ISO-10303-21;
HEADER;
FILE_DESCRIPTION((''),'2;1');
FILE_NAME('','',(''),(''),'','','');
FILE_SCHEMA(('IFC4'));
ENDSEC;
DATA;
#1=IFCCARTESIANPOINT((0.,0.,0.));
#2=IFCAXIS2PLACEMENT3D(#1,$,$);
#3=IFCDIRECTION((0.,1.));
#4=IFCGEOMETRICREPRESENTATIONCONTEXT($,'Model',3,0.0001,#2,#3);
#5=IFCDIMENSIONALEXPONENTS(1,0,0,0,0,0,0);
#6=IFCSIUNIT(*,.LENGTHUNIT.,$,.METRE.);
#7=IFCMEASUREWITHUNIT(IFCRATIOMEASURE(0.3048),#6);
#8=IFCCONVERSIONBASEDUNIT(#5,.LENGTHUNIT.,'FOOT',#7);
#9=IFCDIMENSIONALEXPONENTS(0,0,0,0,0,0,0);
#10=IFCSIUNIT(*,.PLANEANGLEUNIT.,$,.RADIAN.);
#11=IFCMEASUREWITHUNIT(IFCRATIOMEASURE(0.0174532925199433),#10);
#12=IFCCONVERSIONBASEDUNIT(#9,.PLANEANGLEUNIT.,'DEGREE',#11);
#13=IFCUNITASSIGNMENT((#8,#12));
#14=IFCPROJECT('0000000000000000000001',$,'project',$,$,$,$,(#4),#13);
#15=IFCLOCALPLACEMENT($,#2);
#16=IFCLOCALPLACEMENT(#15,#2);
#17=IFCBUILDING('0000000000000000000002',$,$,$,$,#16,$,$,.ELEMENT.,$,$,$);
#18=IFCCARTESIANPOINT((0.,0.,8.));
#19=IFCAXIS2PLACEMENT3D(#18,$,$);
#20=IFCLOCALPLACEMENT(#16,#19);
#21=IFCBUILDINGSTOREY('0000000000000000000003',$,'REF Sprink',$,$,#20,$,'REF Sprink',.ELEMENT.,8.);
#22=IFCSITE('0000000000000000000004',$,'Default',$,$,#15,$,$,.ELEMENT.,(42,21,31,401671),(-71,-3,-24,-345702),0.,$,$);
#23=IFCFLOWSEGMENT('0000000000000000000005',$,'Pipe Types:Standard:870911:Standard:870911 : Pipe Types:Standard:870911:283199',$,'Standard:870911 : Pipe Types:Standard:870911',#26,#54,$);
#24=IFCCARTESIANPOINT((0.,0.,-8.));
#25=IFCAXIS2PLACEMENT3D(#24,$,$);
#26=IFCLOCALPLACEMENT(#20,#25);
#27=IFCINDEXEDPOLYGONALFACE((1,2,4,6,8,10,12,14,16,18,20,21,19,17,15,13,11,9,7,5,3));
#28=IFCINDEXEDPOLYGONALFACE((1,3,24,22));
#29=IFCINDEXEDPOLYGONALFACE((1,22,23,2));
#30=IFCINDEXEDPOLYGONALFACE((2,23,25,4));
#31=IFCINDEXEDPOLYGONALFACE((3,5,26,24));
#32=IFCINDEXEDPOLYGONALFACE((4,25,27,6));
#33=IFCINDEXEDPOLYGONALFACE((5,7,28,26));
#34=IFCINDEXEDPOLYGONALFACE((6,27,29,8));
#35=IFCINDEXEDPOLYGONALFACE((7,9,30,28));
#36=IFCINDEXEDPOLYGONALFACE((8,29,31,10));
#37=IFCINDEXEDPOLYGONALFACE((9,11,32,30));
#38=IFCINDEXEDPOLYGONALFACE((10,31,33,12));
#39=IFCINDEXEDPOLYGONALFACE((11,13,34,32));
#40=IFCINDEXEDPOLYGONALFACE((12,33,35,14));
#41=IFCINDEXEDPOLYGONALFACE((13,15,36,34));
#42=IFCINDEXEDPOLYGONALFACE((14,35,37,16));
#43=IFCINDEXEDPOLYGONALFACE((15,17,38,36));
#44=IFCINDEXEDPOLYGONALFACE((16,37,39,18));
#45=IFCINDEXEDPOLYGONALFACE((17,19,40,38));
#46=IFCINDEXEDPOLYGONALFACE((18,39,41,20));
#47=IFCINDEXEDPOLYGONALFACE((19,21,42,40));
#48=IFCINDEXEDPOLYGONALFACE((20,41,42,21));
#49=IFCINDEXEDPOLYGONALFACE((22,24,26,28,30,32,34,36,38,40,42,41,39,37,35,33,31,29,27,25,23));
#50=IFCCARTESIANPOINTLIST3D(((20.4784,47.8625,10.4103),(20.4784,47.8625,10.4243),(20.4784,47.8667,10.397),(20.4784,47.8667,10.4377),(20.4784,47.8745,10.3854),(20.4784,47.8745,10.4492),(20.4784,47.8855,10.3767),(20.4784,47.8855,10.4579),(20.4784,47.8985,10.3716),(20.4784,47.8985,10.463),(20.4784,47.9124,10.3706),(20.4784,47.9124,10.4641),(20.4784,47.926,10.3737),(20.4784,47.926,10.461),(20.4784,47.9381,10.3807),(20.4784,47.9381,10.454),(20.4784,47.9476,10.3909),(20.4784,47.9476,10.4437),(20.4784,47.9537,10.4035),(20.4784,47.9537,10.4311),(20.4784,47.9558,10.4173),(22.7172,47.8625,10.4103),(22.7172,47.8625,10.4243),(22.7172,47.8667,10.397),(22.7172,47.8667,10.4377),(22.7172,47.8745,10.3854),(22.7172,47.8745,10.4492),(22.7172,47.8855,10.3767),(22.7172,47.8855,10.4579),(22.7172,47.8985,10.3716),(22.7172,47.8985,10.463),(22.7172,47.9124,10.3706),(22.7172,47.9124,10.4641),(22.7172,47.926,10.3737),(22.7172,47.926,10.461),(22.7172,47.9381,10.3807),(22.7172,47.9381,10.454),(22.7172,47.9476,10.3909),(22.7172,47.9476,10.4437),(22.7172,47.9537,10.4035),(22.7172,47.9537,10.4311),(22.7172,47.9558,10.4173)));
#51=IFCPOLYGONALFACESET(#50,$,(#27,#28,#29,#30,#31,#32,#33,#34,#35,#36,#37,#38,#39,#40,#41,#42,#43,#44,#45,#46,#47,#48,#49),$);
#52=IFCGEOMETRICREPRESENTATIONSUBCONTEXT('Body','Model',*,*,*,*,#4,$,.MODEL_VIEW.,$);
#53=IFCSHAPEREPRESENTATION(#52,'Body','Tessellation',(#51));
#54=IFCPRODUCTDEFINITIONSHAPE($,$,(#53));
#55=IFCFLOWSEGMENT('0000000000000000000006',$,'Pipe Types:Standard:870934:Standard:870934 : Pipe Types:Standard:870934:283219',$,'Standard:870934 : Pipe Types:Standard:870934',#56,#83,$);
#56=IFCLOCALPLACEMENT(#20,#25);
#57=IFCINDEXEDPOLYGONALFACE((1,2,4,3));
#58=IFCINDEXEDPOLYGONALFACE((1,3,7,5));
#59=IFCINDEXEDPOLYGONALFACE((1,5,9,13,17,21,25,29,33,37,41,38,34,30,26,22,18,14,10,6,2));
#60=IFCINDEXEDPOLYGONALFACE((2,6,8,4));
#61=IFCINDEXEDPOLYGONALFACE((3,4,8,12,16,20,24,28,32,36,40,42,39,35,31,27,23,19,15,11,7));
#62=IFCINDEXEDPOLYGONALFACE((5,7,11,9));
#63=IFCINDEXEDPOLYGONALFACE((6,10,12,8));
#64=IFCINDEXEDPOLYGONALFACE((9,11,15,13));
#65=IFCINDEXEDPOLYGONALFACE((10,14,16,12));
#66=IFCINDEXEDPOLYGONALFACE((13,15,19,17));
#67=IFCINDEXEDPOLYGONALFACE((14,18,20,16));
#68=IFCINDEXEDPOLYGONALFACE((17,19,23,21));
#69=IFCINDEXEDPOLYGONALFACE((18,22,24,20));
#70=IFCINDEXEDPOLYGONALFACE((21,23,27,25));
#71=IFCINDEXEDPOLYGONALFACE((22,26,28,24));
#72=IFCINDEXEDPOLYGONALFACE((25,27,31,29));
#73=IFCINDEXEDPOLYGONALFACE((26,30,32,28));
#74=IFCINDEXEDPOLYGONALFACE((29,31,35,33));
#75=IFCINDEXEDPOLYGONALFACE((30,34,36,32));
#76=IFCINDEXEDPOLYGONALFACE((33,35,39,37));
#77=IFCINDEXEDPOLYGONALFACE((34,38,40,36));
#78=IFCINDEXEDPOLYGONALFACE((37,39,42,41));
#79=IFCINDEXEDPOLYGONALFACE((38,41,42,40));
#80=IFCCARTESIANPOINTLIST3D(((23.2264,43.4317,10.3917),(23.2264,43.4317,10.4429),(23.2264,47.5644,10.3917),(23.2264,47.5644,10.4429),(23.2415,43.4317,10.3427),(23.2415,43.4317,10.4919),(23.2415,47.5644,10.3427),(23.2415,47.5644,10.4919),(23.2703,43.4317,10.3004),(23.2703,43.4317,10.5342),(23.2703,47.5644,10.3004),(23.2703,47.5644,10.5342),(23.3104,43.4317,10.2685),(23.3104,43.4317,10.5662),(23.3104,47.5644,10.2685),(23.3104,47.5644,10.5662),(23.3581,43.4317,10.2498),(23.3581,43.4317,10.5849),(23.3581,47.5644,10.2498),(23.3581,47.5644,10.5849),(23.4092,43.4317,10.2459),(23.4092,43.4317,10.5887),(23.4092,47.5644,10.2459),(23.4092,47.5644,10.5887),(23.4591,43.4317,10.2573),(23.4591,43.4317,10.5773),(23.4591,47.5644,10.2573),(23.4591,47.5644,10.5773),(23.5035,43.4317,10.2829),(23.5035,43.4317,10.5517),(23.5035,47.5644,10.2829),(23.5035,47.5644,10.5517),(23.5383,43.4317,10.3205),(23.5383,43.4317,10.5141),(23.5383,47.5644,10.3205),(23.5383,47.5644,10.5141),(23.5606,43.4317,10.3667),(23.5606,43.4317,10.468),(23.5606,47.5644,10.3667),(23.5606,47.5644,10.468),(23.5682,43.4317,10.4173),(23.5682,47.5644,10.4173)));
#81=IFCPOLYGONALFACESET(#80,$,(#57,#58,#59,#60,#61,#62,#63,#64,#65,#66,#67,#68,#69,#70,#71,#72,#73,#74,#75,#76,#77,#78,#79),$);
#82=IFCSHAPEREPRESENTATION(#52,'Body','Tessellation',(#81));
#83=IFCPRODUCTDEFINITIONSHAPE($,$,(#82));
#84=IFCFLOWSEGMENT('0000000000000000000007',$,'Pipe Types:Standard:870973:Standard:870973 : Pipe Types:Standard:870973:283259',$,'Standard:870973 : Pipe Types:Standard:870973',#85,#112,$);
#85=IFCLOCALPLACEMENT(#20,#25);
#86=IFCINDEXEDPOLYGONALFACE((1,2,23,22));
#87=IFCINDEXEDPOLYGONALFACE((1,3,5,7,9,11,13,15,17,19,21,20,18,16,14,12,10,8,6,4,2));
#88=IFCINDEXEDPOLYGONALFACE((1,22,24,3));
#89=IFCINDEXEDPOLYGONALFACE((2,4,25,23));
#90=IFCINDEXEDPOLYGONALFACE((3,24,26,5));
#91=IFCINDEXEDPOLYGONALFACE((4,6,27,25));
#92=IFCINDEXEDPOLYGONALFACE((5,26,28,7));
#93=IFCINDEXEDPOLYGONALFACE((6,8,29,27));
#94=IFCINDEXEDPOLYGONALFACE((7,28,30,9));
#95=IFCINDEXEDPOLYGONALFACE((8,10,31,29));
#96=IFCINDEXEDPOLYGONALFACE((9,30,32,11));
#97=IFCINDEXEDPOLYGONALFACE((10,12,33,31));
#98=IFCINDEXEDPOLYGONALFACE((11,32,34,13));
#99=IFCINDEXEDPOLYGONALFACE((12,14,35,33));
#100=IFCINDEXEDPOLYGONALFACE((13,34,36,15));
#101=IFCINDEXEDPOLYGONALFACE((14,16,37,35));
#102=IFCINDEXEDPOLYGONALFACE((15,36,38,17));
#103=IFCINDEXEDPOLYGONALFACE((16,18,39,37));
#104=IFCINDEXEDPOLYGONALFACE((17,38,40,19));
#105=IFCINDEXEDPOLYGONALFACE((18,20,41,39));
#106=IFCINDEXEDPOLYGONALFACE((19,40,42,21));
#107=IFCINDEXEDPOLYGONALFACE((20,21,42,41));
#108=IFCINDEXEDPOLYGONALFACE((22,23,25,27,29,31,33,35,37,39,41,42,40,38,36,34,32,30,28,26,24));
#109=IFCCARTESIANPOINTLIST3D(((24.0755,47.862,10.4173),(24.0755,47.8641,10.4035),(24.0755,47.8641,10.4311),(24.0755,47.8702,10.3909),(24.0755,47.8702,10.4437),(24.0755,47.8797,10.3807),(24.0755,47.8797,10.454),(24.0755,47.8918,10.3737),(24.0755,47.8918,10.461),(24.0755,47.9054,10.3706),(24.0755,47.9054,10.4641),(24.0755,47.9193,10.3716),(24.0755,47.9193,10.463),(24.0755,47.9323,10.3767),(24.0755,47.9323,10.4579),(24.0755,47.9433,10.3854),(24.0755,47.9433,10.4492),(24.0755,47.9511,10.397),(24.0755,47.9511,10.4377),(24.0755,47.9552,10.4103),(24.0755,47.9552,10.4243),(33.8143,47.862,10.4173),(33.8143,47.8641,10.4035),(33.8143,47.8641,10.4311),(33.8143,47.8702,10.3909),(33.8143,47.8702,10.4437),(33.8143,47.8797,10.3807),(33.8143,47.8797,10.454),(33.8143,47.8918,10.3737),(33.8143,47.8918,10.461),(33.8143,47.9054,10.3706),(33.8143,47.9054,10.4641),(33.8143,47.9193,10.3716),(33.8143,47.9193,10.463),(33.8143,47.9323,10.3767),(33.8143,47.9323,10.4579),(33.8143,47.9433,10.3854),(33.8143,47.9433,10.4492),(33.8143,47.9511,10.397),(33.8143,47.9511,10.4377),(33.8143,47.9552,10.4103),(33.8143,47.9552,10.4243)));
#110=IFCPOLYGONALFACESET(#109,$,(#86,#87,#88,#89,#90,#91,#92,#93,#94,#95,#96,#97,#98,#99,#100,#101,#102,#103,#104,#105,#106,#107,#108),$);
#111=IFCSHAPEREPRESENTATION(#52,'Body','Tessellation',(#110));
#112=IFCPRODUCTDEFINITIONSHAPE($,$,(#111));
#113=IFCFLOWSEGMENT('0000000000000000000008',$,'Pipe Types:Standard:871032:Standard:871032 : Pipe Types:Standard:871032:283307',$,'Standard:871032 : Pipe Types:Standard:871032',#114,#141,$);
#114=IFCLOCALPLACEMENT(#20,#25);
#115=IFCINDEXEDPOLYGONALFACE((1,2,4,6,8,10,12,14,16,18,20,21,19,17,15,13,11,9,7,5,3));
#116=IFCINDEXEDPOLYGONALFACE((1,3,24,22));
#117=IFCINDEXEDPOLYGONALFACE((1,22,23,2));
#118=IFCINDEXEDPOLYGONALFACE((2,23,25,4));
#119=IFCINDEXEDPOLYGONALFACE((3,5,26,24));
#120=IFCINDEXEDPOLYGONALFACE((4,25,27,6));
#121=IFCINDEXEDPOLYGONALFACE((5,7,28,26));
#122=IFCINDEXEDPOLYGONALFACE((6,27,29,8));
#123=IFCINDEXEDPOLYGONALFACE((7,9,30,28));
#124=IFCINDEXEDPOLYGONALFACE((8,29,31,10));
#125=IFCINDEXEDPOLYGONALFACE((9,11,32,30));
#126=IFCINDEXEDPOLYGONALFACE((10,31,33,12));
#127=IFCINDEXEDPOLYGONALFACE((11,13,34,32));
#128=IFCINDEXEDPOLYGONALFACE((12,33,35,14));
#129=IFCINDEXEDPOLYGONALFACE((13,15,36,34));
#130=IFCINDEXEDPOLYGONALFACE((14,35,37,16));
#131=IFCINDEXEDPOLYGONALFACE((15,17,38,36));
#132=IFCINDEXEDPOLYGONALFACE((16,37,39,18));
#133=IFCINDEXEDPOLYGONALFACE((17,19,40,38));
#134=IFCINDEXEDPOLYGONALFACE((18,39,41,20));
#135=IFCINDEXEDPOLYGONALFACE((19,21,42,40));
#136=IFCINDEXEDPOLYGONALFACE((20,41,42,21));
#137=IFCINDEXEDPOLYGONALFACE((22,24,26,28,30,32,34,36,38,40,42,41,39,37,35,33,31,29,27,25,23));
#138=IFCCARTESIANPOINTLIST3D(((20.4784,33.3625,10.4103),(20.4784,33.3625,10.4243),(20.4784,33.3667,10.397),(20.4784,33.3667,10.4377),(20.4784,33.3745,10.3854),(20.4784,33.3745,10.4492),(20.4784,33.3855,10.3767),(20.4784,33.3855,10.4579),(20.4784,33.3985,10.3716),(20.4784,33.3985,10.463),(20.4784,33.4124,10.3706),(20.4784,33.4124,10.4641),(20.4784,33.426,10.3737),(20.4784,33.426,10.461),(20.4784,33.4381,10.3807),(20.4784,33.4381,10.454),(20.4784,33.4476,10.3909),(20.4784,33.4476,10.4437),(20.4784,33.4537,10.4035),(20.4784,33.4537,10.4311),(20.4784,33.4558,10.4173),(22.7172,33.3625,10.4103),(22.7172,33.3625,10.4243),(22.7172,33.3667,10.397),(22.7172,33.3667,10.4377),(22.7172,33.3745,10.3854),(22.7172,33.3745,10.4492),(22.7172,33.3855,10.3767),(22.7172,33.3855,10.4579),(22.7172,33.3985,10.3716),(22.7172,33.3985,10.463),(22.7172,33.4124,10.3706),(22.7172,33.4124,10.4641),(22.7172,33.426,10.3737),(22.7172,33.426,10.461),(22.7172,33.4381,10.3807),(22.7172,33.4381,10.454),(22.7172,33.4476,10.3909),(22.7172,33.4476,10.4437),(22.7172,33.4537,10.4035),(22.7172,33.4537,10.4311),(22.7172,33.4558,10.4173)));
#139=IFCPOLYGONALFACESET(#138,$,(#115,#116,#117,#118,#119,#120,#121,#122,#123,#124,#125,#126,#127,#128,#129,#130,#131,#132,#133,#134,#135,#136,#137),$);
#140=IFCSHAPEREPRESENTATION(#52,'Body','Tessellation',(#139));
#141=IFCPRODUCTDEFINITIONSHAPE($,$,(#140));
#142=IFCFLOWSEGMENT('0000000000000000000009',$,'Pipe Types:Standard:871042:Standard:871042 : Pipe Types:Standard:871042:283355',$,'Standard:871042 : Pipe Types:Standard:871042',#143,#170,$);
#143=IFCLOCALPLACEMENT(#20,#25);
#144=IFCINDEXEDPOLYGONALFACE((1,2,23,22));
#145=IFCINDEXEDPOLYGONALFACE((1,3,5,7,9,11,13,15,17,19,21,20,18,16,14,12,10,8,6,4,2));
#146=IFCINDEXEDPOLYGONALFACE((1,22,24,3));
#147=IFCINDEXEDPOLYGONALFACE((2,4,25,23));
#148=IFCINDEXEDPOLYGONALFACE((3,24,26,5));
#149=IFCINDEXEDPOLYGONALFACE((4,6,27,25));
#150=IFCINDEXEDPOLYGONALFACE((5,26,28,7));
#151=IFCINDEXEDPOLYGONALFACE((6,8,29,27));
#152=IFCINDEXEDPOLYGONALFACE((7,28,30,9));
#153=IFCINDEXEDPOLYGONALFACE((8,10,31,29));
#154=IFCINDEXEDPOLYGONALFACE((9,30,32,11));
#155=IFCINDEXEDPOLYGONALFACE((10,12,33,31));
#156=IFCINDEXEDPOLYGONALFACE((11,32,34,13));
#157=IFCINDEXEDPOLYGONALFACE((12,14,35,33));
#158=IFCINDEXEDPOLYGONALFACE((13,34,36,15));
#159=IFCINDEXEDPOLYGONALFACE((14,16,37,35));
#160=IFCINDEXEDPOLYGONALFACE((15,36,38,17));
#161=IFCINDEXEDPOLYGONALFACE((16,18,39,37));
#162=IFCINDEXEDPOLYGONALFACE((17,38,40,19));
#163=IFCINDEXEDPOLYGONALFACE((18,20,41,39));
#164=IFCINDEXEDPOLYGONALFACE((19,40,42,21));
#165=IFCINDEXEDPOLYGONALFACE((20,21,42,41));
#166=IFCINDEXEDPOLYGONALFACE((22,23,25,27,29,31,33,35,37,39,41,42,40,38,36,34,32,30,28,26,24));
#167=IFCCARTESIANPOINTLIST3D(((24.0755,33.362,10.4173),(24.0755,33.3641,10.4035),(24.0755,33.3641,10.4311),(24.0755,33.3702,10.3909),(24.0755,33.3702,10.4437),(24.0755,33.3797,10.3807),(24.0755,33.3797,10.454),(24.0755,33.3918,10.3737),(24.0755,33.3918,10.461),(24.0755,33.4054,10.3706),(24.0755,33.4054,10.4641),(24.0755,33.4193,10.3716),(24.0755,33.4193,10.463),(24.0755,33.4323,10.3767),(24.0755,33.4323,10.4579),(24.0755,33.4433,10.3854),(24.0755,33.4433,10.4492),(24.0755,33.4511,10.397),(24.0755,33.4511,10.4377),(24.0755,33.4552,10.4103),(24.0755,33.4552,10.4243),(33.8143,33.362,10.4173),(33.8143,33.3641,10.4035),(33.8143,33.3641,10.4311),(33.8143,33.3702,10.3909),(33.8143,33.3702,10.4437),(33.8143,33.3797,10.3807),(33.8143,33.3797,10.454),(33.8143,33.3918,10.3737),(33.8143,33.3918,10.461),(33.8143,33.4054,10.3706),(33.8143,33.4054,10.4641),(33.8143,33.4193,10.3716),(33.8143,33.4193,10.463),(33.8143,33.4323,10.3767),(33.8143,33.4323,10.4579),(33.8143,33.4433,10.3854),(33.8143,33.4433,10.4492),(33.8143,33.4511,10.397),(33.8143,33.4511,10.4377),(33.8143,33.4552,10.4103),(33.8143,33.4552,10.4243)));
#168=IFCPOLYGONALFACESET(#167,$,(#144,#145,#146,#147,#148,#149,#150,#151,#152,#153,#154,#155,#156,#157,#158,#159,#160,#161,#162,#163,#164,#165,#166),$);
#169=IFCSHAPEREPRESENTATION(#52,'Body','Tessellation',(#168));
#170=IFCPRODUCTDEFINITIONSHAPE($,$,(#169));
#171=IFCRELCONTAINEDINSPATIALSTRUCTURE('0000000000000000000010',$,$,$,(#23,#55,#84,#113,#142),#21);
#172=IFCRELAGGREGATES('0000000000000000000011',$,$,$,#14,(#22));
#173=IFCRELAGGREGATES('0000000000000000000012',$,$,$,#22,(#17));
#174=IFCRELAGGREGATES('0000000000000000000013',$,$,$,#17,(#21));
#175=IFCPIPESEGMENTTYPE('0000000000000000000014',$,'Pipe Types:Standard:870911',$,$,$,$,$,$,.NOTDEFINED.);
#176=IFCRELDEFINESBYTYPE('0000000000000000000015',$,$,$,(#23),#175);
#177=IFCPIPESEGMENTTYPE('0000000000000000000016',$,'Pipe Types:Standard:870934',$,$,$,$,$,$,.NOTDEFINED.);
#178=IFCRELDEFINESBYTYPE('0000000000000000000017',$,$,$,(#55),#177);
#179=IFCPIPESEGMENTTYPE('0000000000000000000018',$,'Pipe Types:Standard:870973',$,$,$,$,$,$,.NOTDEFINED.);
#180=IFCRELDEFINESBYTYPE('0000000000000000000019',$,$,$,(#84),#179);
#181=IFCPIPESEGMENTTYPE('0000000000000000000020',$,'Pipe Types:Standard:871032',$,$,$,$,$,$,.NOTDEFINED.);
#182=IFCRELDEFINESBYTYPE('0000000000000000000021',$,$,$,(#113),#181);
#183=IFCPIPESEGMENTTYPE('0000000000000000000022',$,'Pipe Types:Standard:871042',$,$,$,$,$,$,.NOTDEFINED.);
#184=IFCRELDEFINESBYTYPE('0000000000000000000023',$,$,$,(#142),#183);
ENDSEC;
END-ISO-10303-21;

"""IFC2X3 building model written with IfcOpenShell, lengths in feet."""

from ifc_helpers import new_model, entity, si_unit, converted_unit, direction, frame, origin, origin_2d_with_axis, place, context, subcontext, project, spatial, circle, extrude, source, transform, mapped, type_object, type_shapes, element, save


model = new_model("IFC2X3")

# Units and contexts
model_context = context("Model", 3, precision=0.0001, world=origin(), true_north=direction((0.0, 1.0)))
body_context = subcontext(model_context, "Body", "Model", "MODEL_VIEW")
ifc_project = project(units=[converted_unit("LENGTHUNIT", "FOOT", entity("IfcRatioMeasure", 0.3048), si_unit("LENGTHUNIT", "METRE"), dimensions=[1, 0, 0, 0, 0, 0, 0]), converted_unit("PLANEANGLEUNIT", "DEGREE", entity("IfcRatioMeasure", 0.0174532925199433), si_unit("PLANEANGLEUNIT", "RADIAN"), dimensions=[0, 0, 0, 0, 0, 0, 0])], contexts=[model_context])

# Site, building, storey
site_placement = place(None, origin())
site = spatial("IfcSite", under=ifc_project, at=site_placement, Name="Default", CompositionType="ELEMENT", RefLatitude=(42, 21, 31, 401671), RefLongitude=(-71, -3, -24, -345702), RefElevation=0.0)
building_placement = place(site_placement, origin())
building = spatial("IfcBuilding", under=site, at=building_placement, CompositionType="ELEMENT")
storey_placement = place(building_placement, frame((0.0, 0.0, 8.0)))
storey = spatial("IfcBuildingStorey", under=building, at=storey_placement, Name="REF Sprink", LongName="REF Sprink", CompositionType="ELEMENT", Elevation=8.0)

# Flow segments
pipe_segment_type_1 = type_object("IfcPipeSegmentType", Name="Pipe Types:Standard:870911", PredefinedType="NOTDEFINED")
shared_shape_1 = source(origin(), body_context, "Body", "SweptSolid", [
    extrude(circle(Radius=0.0469, at=origin_2d_with_axis()), frame((20.4784, 47.9089, 10.4173), z_axis=(1.0, 0.0, 0.0), x_axis=(0.0, 1.0, 0.0)), (0.0, 0.0, 1.0), 2.2388),
])
type_shapes(pipe_segment_type_1, [shared_shape_1])
flow_segment_1_placement = place(storey_placement, frame((0.0, 0.0, -8.0)))
element("IfcFlowSegment", 1, at=flow_segment_1_placement, inside=storey, type_object=pipe_segment_type_1, Name="Pipe Types:Standard:870911:Standard:870911 : Pipe Types:Standard:870911:283199", ObjectType="Standard:870911 : Pipe Types:Standard:870911", context=body_context, shape_type="MappedRepresentation", body=[
    mapped(shared_shape_1, transform((0.0, 0.0, 0.0), scale=1.0)),
])
pipe_segment_type_2 = type_object("IfcPipeSegmentType", Name="Pipe Types:Standard:870934", PredefinedType="NOTDEFINED")
shared_shape_2 = source(origin(), body_context, "Body", "SweptSolid", [
    extrude(circle(Radius=0.1719, at=origin_2d_with_axis()), frame((23.3963, 43.4317, 10.4173), z_axis=(0.0, 1.0, 0.0), x_axis=(1.0, 0.0, 0.0)), (0.0, 0.0, 1.0), 4.1327),
])
type_shapes(pipe_segment_type_2, [shared_shape_2])
flow_segment_2_placement = place(storey_placement, frame((0.0, 0.0, -8.0)))
element("IfcFlowSegment", 2, at=flow_segment_2_placement, inside=storey, type_object=pipe_segment_type_2, Name="Pipe Types:Standard:870934:Standard:870934 : Pipe Types:Standard:870934:283219", ObjectType="Standard:870934 : Pipe Types:Standard:870934", context=body_context, shape_type="MappedRepresentation", body=[
    mapped(shared_shape_2, transform((0.0, 0.0, 0.0), scale=1.0)),
])
pipe_segment_type_3 = type_object("IfcPipeSegmentType", Name="Pipe Types:Standard:870973", PredefinedType="NOTDEFINED")
shared_shape_3 = source(origin(), body_context, "Body", "SweptSolid", [
    extrude(circle(Radius=0.0469, at=origin_2d_with_axis()), frame((24.0755, 47.9089, 10.4173), z_axis=(1.0, 0.0, 0.0), x_axis=(0.0, -1.0, 0.0)), (0.0, 0.0, 1.0), 9.7388),
])
type_shapes(pipe_segment_type_3, [shared_shape_3])
flow_segment_3_placement = place(storey_placement, frame((0.0, 0.0, -8.0)))
element("IfcFlowSegment", 3, at=flow_segment_3_placement, inside=storey, type_object=pipe_segment_type_3, Name="Pipe Types:Standard:870973:Standard:870973 : Pipe Types:Standard:870973:283259", ObjectType="Standard:870973 : Pipe Types:Standard:870973", context=body_context, shape_type="MappedRepresentation", body=[
    mapped(shared_shape_3, transform((0.0, 0.0, 0.0), scale=1.0)),
])
pipe_segment_type_4 = type_object("IfcPipeSegmentType", Name="Pipe Types:Standard:871032", PredefinedType="NOTDEFINED")
shared_shape_4 = source(origin(), body_context, "Body", "SweptSolid", [
    extrude(circle(Radius=0.0469, at=origin_2d_with_axis()), frame((20.4784, 33.4089, 10.4173), z_axis=(1.0, 0.0, 0.0), x_axis=(0.0, 1.0, 0.0)), (0.0, 0.0, 1.0), 2.2388),
])
type_shapes(pipe_segment_type_4, [shared_shape_4])
flow_segment_4_placement = place(storey_placement, frame((0.0, 0.0, -8.0)))
element("IfcFlowSegment", 4, at=flow_segment_4_placement, inside=storey, type_object=pipe_segment_type_4, Name="Pipe Types:Standard:871032:Standard:871032 : Pipe Types:Standard:871032:283307", ObjectType="Standard:871032 : Pipe Types:Standard:871032", context=body_context, shape_type="MappedRepresentation", body=[
    mapped(shared_shape_4, transform((0.0, 0.0, 0.0), scale=1.0)),
])
pipe_segment_type_5 = type_object("IfcPipeSegmentType", Name="Pipe Types:Standard:871042", PredefinedType="NOTDEFINED")
shared_shape_5 = source(origin(), body_context, "Body", "SweptSolid", [
    extrude(circle(Radius=0.0469, at=origin_2d_with_axis()), frame((24.0755, 33.4089, 10.4173), z_axis=(1.0, 0.0, 0.0), x_axis=(0.0, -1.0, 0.0)), (0.0, 0.0, 1.0), 9.7388),
])
type_shapes(pipe_segment_type_5, [shared_shape_5])
flow_segment_5_placement = place(storey_placement, frame((0.0, 0.0, -8.0)))
element("IfcFlowSegment", 5, at=flow_segment_5_placement, inside=storey, type_object=pipe_segment_type_5, Name="Pipe Types:Standard:871042:Standard:871042 : Pipe Types:Standard:871042:283355", ObjectType="Standard:871042 : Pipe Types:Standard:871042", context=body_context, shape_type="MappedRepresentation", body=[
    mapped(shared_shape_5, transform((0.0, 0.0, 0.0), scale=1.0)),
])

save(model, "model.ifc")
